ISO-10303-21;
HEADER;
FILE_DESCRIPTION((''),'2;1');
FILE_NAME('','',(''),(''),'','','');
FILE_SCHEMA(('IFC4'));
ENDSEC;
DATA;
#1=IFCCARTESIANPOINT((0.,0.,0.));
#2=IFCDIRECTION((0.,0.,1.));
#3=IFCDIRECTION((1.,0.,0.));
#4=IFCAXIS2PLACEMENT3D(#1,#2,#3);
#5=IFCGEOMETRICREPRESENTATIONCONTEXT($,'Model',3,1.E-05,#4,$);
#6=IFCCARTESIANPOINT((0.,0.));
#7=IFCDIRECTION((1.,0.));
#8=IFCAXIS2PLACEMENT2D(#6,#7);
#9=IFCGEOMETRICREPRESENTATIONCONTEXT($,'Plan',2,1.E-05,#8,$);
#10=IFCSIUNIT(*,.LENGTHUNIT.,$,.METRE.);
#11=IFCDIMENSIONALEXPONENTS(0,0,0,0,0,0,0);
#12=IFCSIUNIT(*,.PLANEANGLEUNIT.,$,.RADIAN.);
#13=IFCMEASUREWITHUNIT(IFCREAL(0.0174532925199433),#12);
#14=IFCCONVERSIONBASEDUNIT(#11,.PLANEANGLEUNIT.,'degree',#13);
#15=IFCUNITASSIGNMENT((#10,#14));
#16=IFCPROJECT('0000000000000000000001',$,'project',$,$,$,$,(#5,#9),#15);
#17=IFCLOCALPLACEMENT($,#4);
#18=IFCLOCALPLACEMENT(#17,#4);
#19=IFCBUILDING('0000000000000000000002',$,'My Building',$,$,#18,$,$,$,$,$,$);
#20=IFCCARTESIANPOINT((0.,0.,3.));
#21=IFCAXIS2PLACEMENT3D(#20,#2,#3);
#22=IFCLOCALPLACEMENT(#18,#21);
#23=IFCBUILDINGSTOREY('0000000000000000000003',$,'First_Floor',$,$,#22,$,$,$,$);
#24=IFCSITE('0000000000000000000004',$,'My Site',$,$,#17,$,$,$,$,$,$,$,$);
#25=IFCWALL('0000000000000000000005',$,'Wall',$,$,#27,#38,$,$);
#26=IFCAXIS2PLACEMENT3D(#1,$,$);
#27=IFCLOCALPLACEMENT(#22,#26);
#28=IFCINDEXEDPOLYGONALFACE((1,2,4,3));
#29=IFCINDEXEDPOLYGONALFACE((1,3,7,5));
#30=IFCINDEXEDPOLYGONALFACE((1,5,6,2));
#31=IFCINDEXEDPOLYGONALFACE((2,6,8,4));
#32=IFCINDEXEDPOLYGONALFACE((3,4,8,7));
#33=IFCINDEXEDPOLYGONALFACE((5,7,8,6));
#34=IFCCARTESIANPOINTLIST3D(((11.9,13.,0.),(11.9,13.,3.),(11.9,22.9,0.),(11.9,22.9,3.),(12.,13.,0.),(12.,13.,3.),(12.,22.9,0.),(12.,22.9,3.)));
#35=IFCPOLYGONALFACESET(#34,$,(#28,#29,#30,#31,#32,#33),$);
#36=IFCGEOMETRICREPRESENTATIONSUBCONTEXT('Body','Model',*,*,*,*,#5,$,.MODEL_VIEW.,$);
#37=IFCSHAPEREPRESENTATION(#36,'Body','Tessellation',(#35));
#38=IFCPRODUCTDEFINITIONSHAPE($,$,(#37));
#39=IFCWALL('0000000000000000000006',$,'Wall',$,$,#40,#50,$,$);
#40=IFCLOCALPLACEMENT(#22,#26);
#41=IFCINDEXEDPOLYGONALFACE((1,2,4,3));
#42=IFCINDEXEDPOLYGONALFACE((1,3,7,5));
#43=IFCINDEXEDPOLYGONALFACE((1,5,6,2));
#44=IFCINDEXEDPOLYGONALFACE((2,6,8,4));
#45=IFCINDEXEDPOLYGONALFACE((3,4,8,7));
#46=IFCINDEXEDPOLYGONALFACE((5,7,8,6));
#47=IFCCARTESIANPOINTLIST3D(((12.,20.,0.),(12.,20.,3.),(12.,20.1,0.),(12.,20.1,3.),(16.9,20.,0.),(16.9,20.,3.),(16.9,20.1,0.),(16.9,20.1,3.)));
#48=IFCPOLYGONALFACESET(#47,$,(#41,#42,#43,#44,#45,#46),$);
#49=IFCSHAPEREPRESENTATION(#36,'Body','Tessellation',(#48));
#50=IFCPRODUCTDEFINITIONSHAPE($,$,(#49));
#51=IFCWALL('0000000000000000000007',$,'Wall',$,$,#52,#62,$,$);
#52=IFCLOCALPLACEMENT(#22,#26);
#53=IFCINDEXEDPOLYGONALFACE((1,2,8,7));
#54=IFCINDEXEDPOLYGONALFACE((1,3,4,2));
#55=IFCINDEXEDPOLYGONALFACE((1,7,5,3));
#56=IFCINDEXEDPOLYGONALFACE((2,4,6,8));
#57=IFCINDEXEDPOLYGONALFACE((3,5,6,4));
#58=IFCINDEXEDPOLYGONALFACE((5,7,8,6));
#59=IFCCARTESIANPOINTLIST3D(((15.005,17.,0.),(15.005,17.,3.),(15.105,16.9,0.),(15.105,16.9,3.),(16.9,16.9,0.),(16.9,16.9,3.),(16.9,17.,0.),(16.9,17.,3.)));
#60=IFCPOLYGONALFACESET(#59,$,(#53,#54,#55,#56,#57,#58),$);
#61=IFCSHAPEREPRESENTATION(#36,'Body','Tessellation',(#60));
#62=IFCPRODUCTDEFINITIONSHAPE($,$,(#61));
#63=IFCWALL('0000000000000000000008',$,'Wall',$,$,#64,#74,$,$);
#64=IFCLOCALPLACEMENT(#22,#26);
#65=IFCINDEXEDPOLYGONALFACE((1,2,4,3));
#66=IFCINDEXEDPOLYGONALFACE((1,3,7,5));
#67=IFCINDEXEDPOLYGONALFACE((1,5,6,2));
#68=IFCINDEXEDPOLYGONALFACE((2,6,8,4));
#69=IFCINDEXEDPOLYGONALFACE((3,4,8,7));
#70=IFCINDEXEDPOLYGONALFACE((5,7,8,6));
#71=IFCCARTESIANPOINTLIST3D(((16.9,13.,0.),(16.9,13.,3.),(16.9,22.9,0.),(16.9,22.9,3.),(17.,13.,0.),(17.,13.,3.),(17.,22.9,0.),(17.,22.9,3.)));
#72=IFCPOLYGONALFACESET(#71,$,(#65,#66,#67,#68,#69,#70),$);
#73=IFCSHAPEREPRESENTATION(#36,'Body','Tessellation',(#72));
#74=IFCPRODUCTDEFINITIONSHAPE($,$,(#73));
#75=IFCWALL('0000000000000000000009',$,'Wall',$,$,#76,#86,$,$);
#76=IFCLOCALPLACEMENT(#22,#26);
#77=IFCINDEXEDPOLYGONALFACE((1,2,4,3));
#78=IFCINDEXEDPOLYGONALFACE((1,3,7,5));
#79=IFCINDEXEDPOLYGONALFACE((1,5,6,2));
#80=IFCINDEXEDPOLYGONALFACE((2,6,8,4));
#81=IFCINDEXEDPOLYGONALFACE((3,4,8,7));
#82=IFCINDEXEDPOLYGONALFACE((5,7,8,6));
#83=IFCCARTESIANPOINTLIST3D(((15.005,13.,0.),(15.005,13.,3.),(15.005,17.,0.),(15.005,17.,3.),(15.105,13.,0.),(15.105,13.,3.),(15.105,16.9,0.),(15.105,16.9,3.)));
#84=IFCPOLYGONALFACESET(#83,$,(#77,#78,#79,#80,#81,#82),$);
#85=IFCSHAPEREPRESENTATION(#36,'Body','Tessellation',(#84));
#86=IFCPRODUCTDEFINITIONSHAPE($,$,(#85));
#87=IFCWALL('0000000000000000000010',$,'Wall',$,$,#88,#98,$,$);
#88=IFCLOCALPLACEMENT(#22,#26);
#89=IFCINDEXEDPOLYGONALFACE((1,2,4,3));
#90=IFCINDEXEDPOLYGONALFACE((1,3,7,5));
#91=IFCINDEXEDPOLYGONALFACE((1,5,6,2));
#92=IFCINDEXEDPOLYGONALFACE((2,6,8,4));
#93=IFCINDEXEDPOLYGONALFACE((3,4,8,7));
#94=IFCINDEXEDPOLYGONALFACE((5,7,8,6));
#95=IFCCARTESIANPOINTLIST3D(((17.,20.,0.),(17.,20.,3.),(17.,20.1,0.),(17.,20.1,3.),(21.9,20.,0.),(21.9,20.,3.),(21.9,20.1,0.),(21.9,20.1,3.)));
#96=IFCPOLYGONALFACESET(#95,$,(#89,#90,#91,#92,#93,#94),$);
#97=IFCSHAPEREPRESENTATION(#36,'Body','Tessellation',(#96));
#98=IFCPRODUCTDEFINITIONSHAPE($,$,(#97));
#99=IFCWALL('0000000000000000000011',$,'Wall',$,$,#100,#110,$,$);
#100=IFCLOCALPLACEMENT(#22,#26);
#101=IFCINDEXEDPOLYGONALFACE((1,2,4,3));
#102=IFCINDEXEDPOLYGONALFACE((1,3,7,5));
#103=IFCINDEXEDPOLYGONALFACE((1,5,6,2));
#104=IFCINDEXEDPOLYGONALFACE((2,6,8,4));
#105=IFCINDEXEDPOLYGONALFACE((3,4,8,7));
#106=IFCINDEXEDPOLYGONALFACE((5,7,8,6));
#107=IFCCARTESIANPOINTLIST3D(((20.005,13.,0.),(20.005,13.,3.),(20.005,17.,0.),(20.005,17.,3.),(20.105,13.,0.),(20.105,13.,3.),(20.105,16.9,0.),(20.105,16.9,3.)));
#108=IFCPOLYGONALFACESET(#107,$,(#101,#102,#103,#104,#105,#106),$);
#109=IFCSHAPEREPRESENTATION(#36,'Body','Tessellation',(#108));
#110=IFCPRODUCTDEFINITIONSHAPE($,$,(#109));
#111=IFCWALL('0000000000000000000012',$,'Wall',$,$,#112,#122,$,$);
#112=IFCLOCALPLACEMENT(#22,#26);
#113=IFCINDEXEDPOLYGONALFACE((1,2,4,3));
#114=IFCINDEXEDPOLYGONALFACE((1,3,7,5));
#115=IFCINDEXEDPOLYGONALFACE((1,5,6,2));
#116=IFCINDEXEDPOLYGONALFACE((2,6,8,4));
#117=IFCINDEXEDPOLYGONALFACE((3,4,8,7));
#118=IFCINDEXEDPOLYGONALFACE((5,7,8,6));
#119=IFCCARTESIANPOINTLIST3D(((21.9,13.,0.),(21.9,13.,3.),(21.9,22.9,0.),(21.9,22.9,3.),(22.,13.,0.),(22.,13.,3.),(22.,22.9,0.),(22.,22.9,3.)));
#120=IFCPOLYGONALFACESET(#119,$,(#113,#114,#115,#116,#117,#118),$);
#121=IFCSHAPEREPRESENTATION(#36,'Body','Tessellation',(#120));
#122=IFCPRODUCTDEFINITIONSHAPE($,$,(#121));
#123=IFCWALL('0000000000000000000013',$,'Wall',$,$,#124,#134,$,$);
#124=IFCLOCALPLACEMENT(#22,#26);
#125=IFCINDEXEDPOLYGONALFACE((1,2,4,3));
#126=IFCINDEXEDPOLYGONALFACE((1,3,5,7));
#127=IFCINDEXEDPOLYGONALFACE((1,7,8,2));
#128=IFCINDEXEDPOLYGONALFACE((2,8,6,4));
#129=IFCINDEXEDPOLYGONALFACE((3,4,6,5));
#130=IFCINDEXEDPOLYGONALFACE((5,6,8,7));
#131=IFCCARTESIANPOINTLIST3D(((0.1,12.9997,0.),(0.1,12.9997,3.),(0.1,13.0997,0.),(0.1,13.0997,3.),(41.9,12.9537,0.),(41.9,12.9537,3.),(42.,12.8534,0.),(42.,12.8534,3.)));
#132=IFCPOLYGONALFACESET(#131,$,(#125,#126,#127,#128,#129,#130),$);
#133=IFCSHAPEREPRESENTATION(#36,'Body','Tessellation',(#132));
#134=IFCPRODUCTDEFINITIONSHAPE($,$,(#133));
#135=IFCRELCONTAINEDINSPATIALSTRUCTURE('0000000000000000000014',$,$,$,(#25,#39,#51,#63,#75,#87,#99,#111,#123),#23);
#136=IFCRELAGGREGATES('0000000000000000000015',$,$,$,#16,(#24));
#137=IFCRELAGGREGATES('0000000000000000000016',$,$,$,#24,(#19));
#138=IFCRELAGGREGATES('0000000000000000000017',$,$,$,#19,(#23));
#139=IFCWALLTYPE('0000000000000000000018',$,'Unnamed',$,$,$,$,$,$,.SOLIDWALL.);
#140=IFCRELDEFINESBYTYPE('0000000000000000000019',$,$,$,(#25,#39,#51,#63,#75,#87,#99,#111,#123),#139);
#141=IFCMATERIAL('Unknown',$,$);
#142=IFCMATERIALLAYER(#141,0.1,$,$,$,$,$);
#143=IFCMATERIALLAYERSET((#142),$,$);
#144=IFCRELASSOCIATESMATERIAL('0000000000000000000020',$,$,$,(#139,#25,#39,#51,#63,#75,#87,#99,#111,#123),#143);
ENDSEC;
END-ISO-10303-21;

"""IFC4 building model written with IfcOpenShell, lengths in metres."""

from ifc_helpers import new_model, entity, si_unit, converted_unit, frame, origin_with_axes, origin_2d_with_axis, place, context, subcontext, project, spatial, line, indexed_curve, outline, extrude, material, layer, layer_set, layer_usage, type_object, element, save


model = new_model("IFC4")

# Units and contexts
model_context = context("Model", 3, precision=1e-05, world=origin_with_axes())
plan_context = context("Plan", 2, precision=1e-05, world=origin_2d_with_axis())
body_context = subcontext(model_context, "Body", "Model", "MODEL_VIEW")
ifc_project = project(units=[si_unit("LENGTHUNIT", "METRE"), converted_unit("PLANEANGLEUNIT", "degree", entity("IfcReal", 0.0174532925199433), si_unit("PLANEANGLEUNIT", "RADIAN"), dimensions=[0, 0, 0, 0, 0, 0, 0])], contexts=[model_context, plan_context])

# Site, building, storey
site_placement = place(None, origin_with_axes())
site = spatial("IfcSite", under=ifc_project, at=site_placement, Name="My Site")
building_placement = place(site_placement, origin_with_axes())
building = spatial("IfcBuilding", under=site, at=building_placement, Name="My Building")
storey_placement = place(building_placement, frame((0.0, 0.0, 3.0), z_axis=(0.0, 0.0, 1.0), x_axis=(1.0, 0.0, 0.0)))
storey = spatial("IfcBuildingStorey", under=building, at=storey_placement, Name="First_Floor")

# Shared definitions
ifc_material = material(Name="Unknown")

# Walls
ifc_layer_1 = layer(ifc_material, 0.1)
ifc_layer_set_1 = layer_set([ifc_layer_1])
wall_type = type_object("IfcWallType", Name="Unnamed", PredefinedType="SOLIDWALL", material=ifc_layer_set_1)
ifc_layer_usage_1 = layer_usage(ifc_layer_set_1, "AXIS2", "POSITIVE", 0.0)
wall_1_placement = place(storey_placement, frame((11.9, 22.9, 0.0), z_axis=(0.0, 0.0, 1.0), x_axis=(0.0, -1.0, 0.0)))
element("IfcWall", 1, at=wall_1_placement, inside=storey, type_object=wall_type, material=ifc_layer_usage_1, Name="Wall", context=body_context, shape_type="SweptSolid", body=[
    extrude(outline(indexed_curve([(0.0, 0.0), (0.0, 0.1), (9.9, 0.1), (9.9, 0.0)], segments=[line(1, 2, 3, 4, 1)])), origin_with_axes(), (0.0, 0.0, 1.0), 3.0),
])
ifc_layer_usage_2 = layer_usage(ifc_layer_set_1, "AXIS2", "POSITIVE", 0.0)
wall_2_placement = place(storey_placement, frame((12.0, 20.0, 0.0), z_axis=(0.0, 0.0, 1.0), x_axis=(1.0, 0.0, 0.0)))
element("IfcWall", 2, at=wall_2_placement, inside=storey, type_object=wall_type, material=ifc_layer_usage_2, Name="Wall", context=body_context, shape_type="SweptSolid", body=[
    extrude(outline(indexed_curve([(0.0, 0.0), (0.0, 0.1), (4.9, 0.1), (4.9, 0.0)], segments=[line(1, 2, 3, 4, 1)])), origin_with_axes(), (0.0, 0.0, 1.0), 3.0),
])
ifc_layer_usage_3 = layer_usage(ifc_layer_set_1, "AXIS2", "POSITIVE", 0.0)
wall_3_placement = place(storey_placement, frame((16.9, 17.0, 0.0), z_axis=(0.0, 0.0, 1.0), x_axis=(-1.0, 0.0, 0.0)))
element("IfcWall", 3, at=wall_3_placement, inside=storey, type_object=wall_type, material=ifc_layer_usage_3, Name="Wall", context=body_context, shape_type="SweptSolid", body=[
    extrude(outline(indexed_curve([(0.0, 0.0), (0.0, 0.1), (1.795, 0.1), (1.895, 0.0)], segments=[line(1, 2, 3, 4, 1)])), origin_with_axes(), (0.0, 0.0, 1.0), 3.0),
])
ifc_layer_usage_4 = layer_usage(ifc_layer_set_1, "AXIS2", "POSITIVE", 0.0)
wall_4_placement = place(storey_placement, frame((16.9, 22.9, 0.0), z_axis=(0.0, 0.0, 1.0), x_axis=(0.0, -1.0, 0.0)))
element("IfcWall", 4, at=wall_4_placement, inside=storey, type_object=wall_type, material=ifc_layer_usage_4, Name="Wall", context=body_context, shape_type="SweptSolid", body=[
    extrude(outline(indexed_curve([(0.0, 0.0), (0.0, 0.1), (9.9, 0.1), (9.9, 0.0)], segments=[line(1, 2, 3, 4, 1)])), origin_with_axes(), (0.0, 0.0, 1.0), 3.0),
])
ifc_layer_usage_5 = layer_usage(ifc_layer_set_1, "AXIS2", "POSITIVE", 0.0)
wall_5_placement = place(storey_placement, frame((15.005, 17.0, 0.0), z_axis=(0.0, 0.0, 1.0), x_axis=(0.0, -1.0, 0.0)))
element("IfcWall", 5, at=wall_5_placement, inside=storey, type_object=wall_type, material=ifc_layer_usage_5, Name="Wall", context=body_context, shape_type="SweptSolid", body=[
    extrude(outline(indexed_curve([(0.0, 0.0), (0.1, 0.1), (4.0, 0.1), (4.0, 0.0)], segments=[line(1, 2, 3, 4, 1)])), origin_with_axes(), (0.0, 0.0, 1.0), 3.0),
])
ifc_layer_usage_6 = layer_usage(ifc_layer_set_1, "AXIS2", "POSITIVE", 0.0)
wall_6_placement = place(storey_placement, frame((17.0, 20.0, 0.0), z_axis=(0.0, 0.0, 1.0), x_axis=(1.0, 0.0, 0.0)))
element("IfcWall", 6, at=wall_6_placement, inside=storey, type_object=wall_type, material=ifc_layer_usage_6, Name="Wall", context=body_context, shape_type="SweptSolid", body=[
    extrude(outline(indexed_curve([(0.0, 0.0), (0.0, 0.1), (4.9, 0.1), (4.9, 0.0)], segments=[line(1, 2, 3, 4, 1)])), origin_with_axes(), (0.0, 0.0, 1.0), 3.0),
])
ifc_layer_usage_7 = layer_usage(ifc_layer_set_1, "AXIS2", "POSITIVE", 0.0)
wall_7_placement = place(storey_placement, frame((20.005, 17.0, 0.0), z_axis=(0.0, 0.0, 1.0), x_axis=(0.0, -1.0, 0.0)))
element("IfcWall", 7, at=wall_7_placement, inside=storey, type_object=wall_type, material=ifc_layer_usage_7, Name="Wall", context=body_context, shape_type="SweptSolid", body=[
    extrude(outline(indexed_curve([(0.0, 0.0), (0.1, 0.1), (4.0, 0.1), (4.0, 0.0)], segments=[line(1, 2, 3, 4, 1)])), origin_with_axes(), (0.0, 0.0, 1.0), 3.0),
])
ifc_layer_usage_8 = layer_usage(ifc_layer_set_1, "AXIS2", "POSITIVE", 0.0)
wall_8_placement = place(storey_placement, frame((21.9, 22.9, 0.0), z_axis=(0.0, 0.0, 1.0), x_axis=(0.0, -1.0, 0.0)))
element("IfcWall", 8, at=wall_8_placement, inside=storey, type_object=wall_type, material=ifc_layer_usage_8, Name="Wall", context=body_context, shape_type="SweptSolid", body=[
    extrude(outline(indexed_curve([(0.0, 0.0), (0.0, 0.1), (9.9, 0.1), (9.9, 0.0)], segments=[line(1, 2, 3, 4, 1)])), origin_with_axes(), (0.0, 0.0, 1.0), 3.0),
])
ifc_layer_usage_9 = layer_usage(ifc_layer_set_1, "AXIS2", "POSITIVE", 0.0)
wall_9_placement = place(storey_placement, frame((0.1, 12.9997, 0.0), z_axis=(0.0, 0.0, 1.0), x_axis=(0.999994, -0.003491, 0.0)))
element("IfcWall", 9, at=wall_9_placement, inside=storey, type_object=wall_type, material=ifc_layer_usage_9, Name="Wall", context=body_context, shape_type="SweptSolid", body=[
    extrude(outline(indexed_curve([(0.0, 0.0), (-0.0003, 0.1), (41.7999, 0.1), (41.9003, 0.0)], segments=[line(1, 2, 3, 4, 1)])), origin_with_axes(), (0.0, 0.0, 1.0), 3.0),
])

save(model, "model.ifc")
